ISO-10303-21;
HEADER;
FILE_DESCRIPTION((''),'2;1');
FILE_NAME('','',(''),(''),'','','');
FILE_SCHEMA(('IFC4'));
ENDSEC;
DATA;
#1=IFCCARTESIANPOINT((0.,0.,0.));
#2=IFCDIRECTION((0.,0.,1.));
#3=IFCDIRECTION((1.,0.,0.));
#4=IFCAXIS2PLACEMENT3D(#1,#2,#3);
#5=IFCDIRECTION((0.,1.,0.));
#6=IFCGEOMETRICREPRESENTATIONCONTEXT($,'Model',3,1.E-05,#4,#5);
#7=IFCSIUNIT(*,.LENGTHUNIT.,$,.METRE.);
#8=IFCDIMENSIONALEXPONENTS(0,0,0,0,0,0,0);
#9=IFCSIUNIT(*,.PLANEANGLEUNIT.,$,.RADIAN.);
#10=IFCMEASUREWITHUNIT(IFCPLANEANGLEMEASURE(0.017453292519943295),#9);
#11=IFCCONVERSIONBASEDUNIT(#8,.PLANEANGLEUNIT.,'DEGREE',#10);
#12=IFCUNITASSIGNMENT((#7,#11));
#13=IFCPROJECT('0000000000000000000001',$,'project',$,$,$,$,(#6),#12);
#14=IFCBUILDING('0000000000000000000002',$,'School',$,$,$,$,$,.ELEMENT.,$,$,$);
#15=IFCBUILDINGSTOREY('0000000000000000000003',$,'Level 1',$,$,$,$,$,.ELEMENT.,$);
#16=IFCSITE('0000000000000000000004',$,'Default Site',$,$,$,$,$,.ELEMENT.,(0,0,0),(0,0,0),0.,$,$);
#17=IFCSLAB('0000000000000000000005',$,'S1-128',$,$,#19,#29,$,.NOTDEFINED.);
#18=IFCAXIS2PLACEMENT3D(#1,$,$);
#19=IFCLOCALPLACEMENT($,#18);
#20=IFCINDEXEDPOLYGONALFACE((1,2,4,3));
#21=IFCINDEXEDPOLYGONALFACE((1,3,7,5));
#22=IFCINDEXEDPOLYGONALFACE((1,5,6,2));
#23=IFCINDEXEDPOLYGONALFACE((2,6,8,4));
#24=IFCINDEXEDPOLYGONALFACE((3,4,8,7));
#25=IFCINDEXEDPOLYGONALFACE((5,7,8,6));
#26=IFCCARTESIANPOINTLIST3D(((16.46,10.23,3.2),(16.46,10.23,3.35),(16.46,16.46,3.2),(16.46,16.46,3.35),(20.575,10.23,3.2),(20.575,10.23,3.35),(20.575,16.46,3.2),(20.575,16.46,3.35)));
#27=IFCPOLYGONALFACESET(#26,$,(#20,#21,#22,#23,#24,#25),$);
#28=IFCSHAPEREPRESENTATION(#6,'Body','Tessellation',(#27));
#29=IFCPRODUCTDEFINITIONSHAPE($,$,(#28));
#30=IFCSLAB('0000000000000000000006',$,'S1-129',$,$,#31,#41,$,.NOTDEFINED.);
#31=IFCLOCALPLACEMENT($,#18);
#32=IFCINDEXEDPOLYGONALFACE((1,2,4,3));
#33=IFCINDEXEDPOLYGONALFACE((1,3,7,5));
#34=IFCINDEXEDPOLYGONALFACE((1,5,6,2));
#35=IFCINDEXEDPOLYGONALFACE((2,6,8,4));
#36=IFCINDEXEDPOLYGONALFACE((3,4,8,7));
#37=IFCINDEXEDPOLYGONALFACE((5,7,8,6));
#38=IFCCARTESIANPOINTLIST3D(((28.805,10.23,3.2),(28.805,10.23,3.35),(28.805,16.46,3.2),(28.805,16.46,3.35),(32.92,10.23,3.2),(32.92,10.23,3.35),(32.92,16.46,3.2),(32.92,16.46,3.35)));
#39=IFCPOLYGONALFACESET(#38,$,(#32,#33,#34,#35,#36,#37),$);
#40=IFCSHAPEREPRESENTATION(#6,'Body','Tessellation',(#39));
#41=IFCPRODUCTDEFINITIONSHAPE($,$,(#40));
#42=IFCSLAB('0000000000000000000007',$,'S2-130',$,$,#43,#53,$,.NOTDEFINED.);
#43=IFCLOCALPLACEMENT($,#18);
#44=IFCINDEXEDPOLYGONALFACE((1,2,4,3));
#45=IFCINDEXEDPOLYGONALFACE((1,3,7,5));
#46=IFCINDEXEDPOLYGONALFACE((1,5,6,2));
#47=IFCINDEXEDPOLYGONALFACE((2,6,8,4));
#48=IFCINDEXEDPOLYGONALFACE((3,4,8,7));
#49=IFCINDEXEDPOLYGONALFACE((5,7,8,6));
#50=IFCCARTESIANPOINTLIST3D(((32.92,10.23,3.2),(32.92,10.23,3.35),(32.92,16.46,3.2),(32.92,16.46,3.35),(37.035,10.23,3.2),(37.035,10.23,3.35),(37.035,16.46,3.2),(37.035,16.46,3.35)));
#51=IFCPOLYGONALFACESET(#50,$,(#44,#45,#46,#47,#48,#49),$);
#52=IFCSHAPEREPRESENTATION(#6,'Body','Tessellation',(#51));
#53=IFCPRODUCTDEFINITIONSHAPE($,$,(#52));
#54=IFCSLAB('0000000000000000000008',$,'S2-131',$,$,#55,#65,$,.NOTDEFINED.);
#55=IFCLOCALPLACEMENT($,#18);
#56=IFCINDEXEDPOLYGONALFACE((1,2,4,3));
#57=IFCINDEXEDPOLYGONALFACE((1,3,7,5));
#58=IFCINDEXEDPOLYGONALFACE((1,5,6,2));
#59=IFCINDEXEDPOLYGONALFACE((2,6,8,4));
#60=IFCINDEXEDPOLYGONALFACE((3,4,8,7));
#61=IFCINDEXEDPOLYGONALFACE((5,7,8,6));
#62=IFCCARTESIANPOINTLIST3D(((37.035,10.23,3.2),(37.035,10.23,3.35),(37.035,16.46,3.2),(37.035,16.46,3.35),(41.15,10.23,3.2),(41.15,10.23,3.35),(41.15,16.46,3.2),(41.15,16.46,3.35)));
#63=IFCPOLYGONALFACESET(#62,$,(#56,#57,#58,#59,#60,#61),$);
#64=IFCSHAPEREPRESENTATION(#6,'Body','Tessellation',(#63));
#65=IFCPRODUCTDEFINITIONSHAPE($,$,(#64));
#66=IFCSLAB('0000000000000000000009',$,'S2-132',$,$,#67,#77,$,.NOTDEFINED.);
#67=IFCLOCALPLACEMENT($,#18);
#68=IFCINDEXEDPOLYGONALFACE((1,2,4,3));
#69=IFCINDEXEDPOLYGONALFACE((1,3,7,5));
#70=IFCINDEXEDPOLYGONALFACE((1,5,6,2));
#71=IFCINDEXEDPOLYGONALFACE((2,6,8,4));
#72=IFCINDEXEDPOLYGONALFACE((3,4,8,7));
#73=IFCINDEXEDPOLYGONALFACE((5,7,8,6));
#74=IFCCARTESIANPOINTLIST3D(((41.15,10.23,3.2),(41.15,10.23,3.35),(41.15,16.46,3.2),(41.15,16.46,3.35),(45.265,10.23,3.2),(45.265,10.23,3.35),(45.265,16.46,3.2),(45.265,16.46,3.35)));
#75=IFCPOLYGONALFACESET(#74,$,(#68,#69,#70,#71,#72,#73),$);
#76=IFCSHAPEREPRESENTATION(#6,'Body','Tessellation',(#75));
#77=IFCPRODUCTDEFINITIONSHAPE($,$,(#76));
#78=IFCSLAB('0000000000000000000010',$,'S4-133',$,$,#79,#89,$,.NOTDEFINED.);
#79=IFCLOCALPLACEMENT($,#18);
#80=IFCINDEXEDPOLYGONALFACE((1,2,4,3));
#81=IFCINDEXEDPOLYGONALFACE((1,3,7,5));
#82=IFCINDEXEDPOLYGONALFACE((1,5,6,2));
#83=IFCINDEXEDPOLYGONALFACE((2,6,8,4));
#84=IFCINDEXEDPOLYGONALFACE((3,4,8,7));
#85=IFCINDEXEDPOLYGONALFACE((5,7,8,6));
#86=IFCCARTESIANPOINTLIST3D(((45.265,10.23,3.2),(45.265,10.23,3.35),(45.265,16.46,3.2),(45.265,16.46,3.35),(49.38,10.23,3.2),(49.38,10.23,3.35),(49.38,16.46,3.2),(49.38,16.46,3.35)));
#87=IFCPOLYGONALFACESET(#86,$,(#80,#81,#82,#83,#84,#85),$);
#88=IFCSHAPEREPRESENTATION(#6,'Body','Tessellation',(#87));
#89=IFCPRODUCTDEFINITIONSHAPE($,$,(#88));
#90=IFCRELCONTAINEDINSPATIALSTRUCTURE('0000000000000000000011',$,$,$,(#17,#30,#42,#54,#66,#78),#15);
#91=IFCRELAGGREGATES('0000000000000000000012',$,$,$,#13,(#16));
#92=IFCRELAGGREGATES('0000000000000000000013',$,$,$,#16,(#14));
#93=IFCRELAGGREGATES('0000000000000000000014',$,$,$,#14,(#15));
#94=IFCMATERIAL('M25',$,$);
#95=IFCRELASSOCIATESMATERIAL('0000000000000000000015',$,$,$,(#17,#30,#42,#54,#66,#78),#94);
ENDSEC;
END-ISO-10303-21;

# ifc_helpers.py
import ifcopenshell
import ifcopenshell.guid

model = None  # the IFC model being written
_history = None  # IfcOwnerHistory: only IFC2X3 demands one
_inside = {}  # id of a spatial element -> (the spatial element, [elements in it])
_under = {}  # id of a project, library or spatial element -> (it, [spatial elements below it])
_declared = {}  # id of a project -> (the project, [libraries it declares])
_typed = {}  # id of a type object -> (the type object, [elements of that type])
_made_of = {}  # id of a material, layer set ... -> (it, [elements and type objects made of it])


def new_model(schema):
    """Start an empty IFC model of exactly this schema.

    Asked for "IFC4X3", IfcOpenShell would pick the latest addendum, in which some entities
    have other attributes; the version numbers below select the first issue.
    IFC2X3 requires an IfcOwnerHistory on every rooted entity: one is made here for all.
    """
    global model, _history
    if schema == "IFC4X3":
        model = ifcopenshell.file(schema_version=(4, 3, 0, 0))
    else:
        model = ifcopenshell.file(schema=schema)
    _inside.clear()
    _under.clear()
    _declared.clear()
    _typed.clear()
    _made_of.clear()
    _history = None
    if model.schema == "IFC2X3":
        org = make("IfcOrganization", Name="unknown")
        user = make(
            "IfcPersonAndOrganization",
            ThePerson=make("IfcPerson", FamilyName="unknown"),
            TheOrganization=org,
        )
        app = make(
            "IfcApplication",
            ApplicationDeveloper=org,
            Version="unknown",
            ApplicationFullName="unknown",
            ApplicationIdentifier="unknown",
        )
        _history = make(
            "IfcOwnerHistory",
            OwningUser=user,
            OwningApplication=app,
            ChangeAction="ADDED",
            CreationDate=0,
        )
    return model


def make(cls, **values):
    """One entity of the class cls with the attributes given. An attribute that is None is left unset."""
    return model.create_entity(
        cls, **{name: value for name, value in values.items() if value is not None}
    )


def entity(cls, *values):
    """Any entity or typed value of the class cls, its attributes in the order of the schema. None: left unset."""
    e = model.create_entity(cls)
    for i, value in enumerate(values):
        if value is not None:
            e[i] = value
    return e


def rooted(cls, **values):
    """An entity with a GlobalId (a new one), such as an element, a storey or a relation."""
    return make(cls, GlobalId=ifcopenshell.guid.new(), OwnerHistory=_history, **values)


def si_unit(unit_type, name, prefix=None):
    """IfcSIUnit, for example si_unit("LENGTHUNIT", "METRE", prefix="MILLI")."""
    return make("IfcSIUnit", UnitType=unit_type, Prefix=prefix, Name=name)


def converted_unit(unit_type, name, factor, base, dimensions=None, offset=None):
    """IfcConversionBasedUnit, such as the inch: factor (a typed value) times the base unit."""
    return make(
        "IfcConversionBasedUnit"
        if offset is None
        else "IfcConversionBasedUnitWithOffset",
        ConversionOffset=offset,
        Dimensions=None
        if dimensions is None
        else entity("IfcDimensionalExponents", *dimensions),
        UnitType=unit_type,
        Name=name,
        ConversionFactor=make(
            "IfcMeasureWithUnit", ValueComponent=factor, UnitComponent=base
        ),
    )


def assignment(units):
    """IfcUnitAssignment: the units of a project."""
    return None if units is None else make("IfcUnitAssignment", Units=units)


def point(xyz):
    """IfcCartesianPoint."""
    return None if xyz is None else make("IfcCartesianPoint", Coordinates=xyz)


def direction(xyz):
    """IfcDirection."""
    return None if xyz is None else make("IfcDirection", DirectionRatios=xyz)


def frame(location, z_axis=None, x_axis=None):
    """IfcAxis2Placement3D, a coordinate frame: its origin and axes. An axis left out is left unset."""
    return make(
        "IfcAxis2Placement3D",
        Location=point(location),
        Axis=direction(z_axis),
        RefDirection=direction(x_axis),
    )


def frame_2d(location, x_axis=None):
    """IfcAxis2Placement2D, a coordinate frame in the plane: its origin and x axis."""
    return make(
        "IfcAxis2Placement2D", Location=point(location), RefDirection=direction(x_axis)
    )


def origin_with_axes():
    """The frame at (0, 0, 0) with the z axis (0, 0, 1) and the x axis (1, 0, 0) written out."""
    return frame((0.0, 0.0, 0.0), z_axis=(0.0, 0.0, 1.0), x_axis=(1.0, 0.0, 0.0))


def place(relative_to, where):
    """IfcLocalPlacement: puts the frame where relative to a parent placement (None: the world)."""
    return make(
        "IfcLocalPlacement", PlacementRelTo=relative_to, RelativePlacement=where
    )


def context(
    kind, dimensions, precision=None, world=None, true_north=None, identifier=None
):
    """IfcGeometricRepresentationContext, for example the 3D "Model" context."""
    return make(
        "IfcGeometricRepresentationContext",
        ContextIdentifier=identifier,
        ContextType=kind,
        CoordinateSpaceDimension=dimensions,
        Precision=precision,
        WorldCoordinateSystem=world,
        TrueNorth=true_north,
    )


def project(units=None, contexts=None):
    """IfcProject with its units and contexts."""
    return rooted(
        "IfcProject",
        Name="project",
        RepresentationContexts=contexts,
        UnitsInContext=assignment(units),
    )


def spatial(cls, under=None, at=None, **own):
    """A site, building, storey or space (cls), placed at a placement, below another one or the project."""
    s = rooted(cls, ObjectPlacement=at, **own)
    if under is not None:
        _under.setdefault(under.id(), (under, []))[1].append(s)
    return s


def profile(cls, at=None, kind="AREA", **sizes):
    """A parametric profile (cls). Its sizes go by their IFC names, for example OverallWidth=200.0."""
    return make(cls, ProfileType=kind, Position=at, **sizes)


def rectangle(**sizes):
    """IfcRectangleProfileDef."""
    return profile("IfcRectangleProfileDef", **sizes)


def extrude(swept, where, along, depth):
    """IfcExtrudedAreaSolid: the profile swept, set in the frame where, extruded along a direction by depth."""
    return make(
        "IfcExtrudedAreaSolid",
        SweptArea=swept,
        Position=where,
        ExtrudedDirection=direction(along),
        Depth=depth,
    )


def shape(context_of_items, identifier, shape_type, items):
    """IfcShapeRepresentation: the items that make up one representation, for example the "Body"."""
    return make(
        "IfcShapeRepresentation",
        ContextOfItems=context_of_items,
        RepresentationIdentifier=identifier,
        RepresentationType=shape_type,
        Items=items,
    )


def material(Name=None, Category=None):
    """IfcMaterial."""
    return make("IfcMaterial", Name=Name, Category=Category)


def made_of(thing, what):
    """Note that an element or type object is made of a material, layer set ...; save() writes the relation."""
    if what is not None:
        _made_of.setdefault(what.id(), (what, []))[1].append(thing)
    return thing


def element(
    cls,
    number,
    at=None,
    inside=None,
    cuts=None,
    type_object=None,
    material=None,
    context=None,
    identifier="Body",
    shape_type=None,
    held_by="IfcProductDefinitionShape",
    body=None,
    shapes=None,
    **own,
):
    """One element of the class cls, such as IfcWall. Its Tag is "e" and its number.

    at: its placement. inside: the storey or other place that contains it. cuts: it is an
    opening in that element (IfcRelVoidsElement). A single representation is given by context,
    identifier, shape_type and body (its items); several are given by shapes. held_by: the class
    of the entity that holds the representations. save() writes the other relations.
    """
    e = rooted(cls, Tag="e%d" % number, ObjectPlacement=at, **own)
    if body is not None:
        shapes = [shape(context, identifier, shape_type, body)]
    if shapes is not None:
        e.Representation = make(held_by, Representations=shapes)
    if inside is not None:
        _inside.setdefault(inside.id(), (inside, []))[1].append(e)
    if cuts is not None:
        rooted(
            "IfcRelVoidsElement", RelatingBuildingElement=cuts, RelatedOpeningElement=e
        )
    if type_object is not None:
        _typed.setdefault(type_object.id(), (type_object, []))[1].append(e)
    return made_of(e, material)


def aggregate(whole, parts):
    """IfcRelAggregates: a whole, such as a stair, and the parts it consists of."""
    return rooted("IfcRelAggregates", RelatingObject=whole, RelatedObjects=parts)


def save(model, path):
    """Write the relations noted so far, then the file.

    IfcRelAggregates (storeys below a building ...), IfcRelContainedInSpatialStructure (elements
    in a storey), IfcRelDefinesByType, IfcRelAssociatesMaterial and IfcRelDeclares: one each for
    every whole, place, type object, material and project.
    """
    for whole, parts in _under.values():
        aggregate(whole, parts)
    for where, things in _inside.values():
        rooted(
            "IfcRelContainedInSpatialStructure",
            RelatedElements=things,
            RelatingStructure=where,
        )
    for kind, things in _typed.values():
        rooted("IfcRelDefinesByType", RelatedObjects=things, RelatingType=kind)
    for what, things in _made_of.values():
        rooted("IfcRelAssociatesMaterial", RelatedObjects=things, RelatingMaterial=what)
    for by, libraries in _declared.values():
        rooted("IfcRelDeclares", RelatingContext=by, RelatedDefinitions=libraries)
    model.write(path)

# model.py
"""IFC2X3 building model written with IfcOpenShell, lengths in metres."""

from ifc_helpers import new_model, entity, si_unit, converted_unit, direction, frame, frame_2d, origin_with_axes, place, context, project, spatial, rectangle, extrude, material, element, save


model = new_model("IFC2X3")

# Units and contexts
model_context = context("Model", 3, precision=1e-05, world=origin_with_axes(), true_north=direction((0.0, 1.0, 0.0)))
ifc_project = project(units=[si_unit("LENGTHUNIT", "METRE"), converted_unit("PLANEANGLEUNIT", "DEGREE", entity("IfcPlaneAngleMeasure", 0.017453292519943295), si_unit("PLANEANGLEUNIT", "RADIAN"), dimensions=[0, 0, 0, 0, 0, 0, 0])], contexts=[model_context])

# Site, building, storey
site = spatial("IfcSite", under=ifc_project, Name="Default Site", CompositionType="ELEMENT", RefLatitude=(0, 0, 0), RefLongitude=(0, 0, 0), RefElevation=0.0)
building = spatial("IfcBuilding", under=site, Name="School", CompositionType="ELEMENT")
storey = spatial("IfcBuildingStorey", under=building, Name="Level 1", CompositionType="ELEMENT")

# Slabs
ifc_material = material(Name="M25")
placement = place(None, origin_with_axes())
element("IfcSlab", 1, at=placement, inside=storey, material=ifc_material, Name="S1-128", PredefinedType="NOTDEFINED", context=model_context, shape_type="SweptSolid", body=[
    extrude(rectangle(XDim=4.115, YDim=6.23, at=frame_2d((0.0, 0.0), x_axis=(1.0, 0.0, 0.0))), frame((18.5175, 13.345, 3.2), z_axis=(0.0, 0.0, 1.0), x_axis=(1.0, 0.0, 0.0)), (0.0, 0.0, 1.0), 0.15),
])
element("IfcSlab", 2, at=placement, inside=storey, material=ifc_material, Name="S1-129", PredefinedType="NOTDEFINED", context=model_context, shape_type="SweptSolid", body=[
    extrude(rectangle(XDim=4.115, YDim=6.23, at=frame_2d((0.0, 0.0), x_axis=(1.0, 0.0, 0.0))), frame((30.8625, 13.345, 3.2), z_axis=(0.0, 0.0, 1.0), x_axis=(1.0, 0.0, 0.0)), (0.0, 0.0, 1.0), 0.15),
])
element("IfcSlab", 3, at=placement, inside=storey, material=ifc_material, Name="S2-130", PredefinedType="NOTDEFINED", context=model_context, shape_type="SweptSolid", body=[
    extrude(rectangle(XDim=4.115, YDim=6.23, at=frame_2d((0.0, 0.0), x_axis=(1.0, 0.0, 0.0))), frame((34.9775, 13.345, 3.2), z_axis=(0.0, 0.0, 1.0), x_axis=(1.0, 0.0, 0.0)), (0.0, 0.0, 1.0), 0.15),
])
element("IfcSlab", 4, at=placement, inside=storey, material=ifc_material, Name="S2-131", PredefinedType="NOTDEFINED", context=model_context, shape_type="SweptSolid", body=[
    extrude(rectangle(XDim=4.115, YDim=6.23, at=frame_2d((0.0, 0.0), x_axis=(1.0, 0.0, 0.0))), frame((39.0925, 13.345, 3.2), z_axis=(0.0, 0.0, 1.0), x_axis=(1.0, 0.0, 0.0)), (0.0, 0.0, 1.0), 0.15),
])
element("IfcSlab", 5, at=placement, inside=storey, material=ifc_material, Name="S2-132", PredefinedType="NOTDEFINED", context=model_context, shape_type="SweptSolid", body=[
    extrude(rectangle(XDim=4.115, YDim=6.23, at=frame_2d((0.0, 0.0), x_axis=(1.0, 0.0, 0.0))), frame((43.2075, 13.345, 3.2), z_axis=(0.0, 0.0, 1.0), x_axis=(1.0, 0.0, 0.0)), (0.0, 0.0, 1.0), 0.15),
])
element("IfcSlab", 6, at=placement, inside=storey, material=ifc_material, Name="S4-133", PredefinedType="NOTDEFINED", context=model_context, shape_type="SweptSolid", body=[
    extrude(rectangle(XDim=4.115, YDim=6.23, at=frame_2d((0.0, 0.0), x_axis=(1.0, 0.0, 0.0))), frame((47.3225, 13.345, 3.2), z_axis=(0.0, 0.0, 1.0), x_axis=(1.0, 0.0, 0.0)), (0.0, 0.0, 1.0), 0.15),
])

save(model, "model.ifc")
